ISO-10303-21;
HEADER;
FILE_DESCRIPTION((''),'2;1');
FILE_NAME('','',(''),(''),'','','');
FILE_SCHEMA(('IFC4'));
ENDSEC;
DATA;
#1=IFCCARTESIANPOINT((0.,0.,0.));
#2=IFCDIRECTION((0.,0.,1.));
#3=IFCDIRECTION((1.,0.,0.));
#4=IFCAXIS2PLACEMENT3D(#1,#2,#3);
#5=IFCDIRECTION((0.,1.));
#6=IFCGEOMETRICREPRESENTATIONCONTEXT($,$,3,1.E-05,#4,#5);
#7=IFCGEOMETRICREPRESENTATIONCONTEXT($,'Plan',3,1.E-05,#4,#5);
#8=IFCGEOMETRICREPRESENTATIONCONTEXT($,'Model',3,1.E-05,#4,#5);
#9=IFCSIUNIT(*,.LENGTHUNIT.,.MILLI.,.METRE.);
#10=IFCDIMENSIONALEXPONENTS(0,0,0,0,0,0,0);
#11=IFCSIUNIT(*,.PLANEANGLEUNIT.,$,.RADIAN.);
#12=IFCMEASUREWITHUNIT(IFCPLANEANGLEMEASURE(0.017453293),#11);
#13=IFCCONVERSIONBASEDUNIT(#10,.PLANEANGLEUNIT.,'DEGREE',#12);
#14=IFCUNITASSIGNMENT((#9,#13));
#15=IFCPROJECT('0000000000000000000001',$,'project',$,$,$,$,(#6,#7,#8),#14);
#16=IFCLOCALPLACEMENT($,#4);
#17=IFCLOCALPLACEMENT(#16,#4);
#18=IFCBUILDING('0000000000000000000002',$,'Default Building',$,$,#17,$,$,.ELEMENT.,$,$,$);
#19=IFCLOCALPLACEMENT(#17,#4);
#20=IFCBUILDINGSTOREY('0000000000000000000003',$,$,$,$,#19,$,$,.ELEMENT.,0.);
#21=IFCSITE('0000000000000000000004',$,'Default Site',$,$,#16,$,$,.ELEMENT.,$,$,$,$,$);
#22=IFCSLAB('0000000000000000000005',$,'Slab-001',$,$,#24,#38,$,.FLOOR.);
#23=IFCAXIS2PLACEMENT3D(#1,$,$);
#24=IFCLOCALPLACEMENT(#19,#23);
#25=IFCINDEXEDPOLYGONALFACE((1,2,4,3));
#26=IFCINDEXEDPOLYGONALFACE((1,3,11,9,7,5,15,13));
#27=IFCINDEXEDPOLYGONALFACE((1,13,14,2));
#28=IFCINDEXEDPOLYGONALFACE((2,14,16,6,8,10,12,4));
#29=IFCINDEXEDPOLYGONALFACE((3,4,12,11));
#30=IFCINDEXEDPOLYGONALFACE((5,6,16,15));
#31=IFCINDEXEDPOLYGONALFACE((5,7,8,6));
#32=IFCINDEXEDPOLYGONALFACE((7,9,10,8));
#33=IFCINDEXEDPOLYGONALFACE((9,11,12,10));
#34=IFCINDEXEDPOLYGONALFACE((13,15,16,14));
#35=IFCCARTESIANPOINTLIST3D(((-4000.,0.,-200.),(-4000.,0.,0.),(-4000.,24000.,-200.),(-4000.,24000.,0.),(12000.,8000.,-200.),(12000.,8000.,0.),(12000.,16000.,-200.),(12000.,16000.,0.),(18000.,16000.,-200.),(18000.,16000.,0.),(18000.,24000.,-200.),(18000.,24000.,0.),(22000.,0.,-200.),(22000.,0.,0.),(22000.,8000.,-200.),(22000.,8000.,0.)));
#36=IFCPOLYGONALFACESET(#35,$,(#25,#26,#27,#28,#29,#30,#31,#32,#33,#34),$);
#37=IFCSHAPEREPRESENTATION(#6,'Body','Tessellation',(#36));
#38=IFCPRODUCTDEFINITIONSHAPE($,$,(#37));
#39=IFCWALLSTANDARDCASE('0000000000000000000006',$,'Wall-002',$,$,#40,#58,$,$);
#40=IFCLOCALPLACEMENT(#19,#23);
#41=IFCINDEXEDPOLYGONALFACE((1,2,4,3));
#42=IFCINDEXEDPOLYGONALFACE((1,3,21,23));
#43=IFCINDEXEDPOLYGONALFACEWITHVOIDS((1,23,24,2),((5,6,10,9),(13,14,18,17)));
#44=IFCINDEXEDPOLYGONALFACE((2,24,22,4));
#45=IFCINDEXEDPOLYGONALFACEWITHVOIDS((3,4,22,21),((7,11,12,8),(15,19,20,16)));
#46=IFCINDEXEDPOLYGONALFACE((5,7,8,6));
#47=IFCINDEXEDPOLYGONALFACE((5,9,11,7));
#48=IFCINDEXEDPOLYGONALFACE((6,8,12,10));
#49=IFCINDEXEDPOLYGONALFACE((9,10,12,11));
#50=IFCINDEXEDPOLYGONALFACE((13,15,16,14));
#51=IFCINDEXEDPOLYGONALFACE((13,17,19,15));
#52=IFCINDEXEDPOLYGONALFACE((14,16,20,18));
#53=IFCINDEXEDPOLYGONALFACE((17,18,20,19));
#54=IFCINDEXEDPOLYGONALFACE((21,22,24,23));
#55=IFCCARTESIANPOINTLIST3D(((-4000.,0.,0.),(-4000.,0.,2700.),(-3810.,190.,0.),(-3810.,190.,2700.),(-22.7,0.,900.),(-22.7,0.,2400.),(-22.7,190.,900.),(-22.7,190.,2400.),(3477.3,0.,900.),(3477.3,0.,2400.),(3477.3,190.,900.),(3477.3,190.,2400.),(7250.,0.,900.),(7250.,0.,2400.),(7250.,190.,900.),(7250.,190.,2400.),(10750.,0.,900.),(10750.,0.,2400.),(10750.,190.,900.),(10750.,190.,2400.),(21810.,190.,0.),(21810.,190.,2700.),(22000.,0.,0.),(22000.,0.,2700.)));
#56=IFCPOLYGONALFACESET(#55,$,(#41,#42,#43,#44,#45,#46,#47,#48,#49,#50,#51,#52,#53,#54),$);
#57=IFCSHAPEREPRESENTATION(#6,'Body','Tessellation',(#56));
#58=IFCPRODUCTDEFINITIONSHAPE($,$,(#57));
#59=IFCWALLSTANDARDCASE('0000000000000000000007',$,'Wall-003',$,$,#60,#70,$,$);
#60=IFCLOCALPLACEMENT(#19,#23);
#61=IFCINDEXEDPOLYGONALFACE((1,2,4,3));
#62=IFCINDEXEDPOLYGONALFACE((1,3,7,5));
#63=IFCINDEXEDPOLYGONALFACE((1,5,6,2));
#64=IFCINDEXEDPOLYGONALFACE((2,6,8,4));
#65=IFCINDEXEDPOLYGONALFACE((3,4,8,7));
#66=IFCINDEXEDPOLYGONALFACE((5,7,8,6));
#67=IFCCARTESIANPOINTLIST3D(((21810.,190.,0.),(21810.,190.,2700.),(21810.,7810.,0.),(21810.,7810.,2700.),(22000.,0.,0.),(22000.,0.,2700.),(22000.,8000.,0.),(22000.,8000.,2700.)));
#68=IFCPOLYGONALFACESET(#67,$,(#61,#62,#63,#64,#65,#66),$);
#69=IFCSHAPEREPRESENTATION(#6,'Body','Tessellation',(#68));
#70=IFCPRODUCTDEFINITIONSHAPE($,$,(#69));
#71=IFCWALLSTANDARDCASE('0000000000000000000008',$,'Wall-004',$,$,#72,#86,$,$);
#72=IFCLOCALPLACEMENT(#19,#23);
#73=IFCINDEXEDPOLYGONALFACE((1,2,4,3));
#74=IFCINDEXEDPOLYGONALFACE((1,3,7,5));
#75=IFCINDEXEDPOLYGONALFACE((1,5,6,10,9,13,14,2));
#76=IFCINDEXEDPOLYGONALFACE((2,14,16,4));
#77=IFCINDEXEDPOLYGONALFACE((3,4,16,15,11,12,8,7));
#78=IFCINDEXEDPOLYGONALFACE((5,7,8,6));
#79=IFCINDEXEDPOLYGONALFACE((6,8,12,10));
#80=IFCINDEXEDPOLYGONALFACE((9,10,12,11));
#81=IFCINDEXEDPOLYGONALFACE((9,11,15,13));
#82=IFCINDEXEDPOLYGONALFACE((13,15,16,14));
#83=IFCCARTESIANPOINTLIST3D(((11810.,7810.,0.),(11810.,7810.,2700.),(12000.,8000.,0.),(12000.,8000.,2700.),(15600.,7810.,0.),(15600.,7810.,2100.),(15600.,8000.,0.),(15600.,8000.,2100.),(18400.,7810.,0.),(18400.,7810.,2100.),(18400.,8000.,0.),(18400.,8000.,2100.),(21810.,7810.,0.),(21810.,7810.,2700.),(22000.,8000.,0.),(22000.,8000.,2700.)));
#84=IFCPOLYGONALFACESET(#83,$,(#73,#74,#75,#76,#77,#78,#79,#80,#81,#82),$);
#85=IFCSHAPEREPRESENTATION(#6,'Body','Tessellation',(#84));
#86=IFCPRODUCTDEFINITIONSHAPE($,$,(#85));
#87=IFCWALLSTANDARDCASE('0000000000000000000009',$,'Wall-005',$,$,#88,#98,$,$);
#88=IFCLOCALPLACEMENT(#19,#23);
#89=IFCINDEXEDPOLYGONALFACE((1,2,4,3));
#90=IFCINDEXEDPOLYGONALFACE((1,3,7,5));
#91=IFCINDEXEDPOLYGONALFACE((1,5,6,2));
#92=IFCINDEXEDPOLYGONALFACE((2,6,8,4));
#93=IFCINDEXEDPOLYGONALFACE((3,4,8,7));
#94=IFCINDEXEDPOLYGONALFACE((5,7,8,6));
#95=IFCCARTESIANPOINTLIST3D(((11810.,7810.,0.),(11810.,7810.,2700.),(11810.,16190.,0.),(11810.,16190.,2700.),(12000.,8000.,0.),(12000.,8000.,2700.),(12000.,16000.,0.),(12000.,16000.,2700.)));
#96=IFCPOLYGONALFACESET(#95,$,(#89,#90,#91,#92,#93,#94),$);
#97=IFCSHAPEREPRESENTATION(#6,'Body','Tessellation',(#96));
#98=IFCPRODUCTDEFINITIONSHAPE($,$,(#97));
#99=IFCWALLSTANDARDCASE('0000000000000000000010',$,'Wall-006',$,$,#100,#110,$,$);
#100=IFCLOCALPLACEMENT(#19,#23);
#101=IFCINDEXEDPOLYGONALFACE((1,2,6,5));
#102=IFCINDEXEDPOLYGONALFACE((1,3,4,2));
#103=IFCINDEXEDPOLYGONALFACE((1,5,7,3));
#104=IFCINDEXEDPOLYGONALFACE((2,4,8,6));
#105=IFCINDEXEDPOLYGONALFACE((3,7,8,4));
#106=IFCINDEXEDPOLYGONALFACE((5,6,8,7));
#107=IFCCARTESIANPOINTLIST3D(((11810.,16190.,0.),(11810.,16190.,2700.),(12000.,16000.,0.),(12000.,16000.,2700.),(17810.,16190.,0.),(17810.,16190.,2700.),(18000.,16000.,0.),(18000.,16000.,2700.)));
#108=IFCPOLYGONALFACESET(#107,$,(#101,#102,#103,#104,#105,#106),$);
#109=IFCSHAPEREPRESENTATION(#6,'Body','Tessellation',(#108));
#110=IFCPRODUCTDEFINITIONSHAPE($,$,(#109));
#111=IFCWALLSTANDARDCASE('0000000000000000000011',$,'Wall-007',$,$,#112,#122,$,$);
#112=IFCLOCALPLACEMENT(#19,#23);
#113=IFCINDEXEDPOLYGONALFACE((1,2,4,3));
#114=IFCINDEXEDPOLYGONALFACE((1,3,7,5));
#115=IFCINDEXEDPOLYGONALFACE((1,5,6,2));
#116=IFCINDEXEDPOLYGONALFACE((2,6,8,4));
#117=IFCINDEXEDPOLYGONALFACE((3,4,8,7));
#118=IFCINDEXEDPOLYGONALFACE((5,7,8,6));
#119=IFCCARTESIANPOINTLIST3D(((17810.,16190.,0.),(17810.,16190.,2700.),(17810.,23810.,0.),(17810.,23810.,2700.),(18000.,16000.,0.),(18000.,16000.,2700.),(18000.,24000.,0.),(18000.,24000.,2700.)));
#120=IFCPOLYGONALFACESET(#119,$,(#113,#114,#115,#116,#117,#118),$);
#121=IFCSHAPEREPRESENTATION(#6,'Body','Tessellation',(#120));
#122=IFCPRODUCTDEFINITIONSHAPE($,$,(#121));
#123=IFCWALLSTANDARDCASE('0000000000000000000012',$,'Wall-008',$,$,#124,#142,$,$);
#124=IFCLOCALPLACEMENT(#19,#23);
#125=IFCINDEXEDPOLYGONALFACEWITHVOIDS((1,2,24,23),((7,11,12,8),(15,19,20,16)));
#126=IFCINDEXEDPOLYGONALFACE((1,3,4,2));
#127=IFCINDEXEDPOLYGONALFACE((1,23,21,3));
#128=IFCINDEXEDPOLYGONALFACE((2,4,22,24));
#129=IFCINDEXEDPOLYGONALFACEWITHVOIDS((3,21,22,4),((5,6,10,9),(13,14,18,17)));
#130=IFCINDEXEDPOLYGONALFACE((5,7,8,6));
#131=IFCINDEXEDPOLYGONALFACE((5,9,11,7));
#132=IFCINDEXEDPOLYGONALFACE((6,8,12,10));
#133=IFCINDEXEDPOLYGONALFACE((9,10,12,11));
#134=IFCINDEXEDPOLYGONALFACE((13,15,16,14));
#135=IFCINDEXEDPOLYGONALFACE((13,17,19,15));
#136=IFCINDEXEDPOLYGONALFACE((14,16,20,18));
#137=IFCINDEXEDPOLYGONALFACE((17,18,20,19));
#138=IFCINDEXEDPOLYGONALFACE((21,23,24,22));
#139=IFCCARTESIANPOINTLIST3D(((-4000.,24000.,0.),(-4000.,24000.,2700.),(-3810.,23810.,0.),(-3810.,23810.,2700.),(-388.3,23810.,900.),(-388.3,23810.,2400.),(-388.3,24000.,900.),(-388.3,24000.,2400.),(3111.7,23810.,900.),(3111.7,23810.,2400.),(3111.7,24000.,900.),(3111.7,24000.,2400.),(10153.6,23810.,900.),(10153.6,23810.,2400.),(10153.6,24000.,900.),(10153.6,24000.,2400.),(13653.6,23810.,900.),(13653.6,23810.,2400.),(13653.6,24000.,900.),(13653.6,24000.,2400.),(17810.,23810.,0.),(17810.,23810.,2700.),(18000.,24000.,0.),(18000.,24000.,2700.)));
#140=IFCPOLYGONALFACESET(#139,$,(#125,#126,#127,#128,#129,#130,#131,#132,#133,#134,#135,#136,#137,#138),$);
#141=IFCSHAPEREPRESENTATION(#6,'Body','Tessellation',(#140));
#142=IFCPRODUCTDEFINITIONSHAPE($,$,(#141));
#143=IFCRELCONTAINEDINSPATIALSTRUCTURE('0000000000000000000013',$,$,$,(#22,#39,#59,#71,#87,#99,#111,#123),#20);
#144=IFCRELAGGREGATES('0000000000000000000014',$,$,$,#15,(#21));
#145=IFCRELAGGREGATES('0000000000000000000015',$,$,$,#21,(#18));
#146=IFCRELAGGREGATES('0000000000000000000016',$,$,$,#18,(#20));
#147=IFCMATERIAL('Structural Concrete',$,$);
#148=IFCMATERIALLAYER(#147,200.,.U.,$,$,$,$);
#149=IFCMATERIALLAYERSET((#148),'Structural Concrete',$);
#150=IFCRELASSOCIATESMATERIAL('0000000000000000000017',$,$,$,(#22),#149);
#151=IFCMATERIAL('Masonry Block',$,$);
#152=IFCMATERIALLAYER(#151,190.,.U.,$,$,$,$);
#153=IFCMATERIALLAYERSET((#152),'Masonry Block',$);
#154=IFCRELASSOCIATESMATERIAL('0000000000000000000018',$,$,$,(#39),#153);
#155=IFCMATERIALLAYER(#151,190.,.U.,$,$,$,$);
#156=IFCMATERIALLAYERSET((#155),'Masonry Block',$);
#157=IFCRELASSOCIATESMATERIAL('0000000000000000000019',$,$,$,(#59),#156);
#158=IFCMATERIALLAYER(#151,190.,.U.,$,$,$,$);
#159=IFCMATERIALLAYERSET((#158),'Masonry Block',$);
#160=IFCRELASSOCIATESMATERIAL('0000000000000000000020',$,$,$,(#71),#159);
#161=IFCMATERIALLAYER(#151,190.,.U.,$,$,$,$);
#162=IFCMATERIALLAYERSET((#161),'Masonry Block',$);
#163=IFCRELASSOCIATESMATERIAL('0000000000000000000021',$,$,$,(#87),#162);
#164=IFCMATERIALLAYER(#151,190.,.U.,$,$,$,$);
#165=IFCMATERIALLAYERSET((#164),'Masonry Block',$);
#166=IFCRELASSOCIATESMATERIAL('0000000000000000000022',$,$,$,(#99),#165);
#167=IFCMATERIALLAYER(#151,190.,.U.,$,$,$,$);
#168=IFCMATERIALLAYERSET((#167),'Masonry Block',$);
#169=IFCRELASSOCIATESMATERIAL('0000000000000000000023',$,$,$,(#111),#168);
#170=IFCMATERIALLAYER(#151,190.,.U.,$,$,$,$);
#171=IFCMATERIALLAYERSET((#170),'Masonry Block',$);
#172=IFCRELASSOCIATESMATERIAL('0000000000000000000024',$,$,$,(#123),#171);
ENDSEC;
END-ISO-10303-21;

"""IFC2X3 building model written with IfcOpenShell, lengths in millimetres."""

from ifc_helpers import new_model, entity, si_unit, converted_unit, direction, frame, origin_with_axes, place, context, project, spatial, polyline, outline, extrude, material, layer, layer_set, layer_usage, element, save


model = new_model("IFC2X3")

# Units and contexts
context_of_model = context(None, 3, precision=1e-05, world=origin_with_axes(), true_north=direction((0.0, 1.0)))
plan_context = context("Plan", 3, precision=1e-05, world=origin_with_axes(), true_north=direction((0.0, 1.0)))
model_context = context("Model", 3, precision=1e-05, world=origin_with_axes(), true_north=direction((0.0, 1.0)))
ifc_project = project(units=[si_unit("LENGTHUNIT", "METRE", prefix="MILLI"), converted_unit("PLANEANGLEUNIT", "DEGREE", entity("IfcPlaneAngleMeasure", 0.017453293), si_unit("PLANEANGLEUNIT", "RADIAN"), dimensions=[0, 0, 0, 0, 0, 0, 0])], contexts=[context_of_model, plan_context, model_context])

# Site, building, storey
site_placement = place(None, origin_with_axes())
site = spatial("IfcSite", under=ifc_project, at=site_placement, Name="Default Site", CompositionType="ELEMENT")
building_placement = place(site_placement, origin_with_axes())
building = spatial("IfcBuilding", under=site, at=building_placement, Name="Default Building", CompositionType="ELEMENT")
storey_placement = place(building_placement, origin_with_axes())
storey = spatial("IfcBuildingStorey", under=building, at=storey_placement, CompositionType="ELEMENT", Elevation=0.0)

# Slab
ifc_material_1 = material(Name="Structural Concrete")
ifc_layer_1 = layer(ifc_material_1, 200.0, ventilated="UNKNOWN")
ifc_layer_set_1 = layer_set([ifc_layer_1], Name="Structural Concrete")
ifc_layer_usage_1 = layer_usage(ifc_layer_set_1, "AXIS3", "NEGATIVE", 200.0)
slab_placement = place(storey_placement, frame((-4000.0, 0.0, -200.0), z_axis=(0.0, 0.0, 1.0), x_axis=(0.0, 1.0, 0.0)))
element("IfcSlab", 1, at=slab_placement, inside=storey, material=ifc_layer_usage_1, Name="Slab-001", PredefinedType="FLOOR", context=context_of_model, shape_type="SweptSolid", body=[
    extrude(outline(polyline([(0.0, 0.0), (24000.0, 0.0), (24000.0, -22000.0), (16000.0, -22000.0), (16000.0, -16000.0), (8000.0, -16000.0), (8000.0, -26000.0), (0.0, -26000.0), (0.0, 0.0)])), origin_with_axes(), (0.0, 0.0, 1.0), 200.0),
])

# Wall, openings
ifc_material_2 = material(Name="Masonry Block")
ifc_layer_2 = layer(ifc_material_2, 190.0, ventilated="UNKNOWN")
ifc_layer_set_2 = layer_set([ifc_layer_2], Name="Masonry Block")
ifc_layer_usage_2 = layer_usage(ifc_layer_set_2, "AXIS2", "POSITIVE", 0.0)
wall_1_placement = place(storey_placement, frame((-4000.0, 0.0, 0.0), z_axis=(0.0, 0.0, 1.0), x_axis=(1.0, 0.0, 0.0)))
wall_1 = element("IfcWallStandardCase", 2, at=wall_1_placement, inside=storey, material=ifc_layer_usage_2, Name="Wall-002", context=context_of_model, shape_type="SweptSolid", body=[
    extrude(outline(polyline([(0.0, 0.0), (26000.0, 0.0), (25810.0, 190.0), (190.0, 190.0), (0.0, 0.0)])), origin_with_axes(), (0.0, 0.0, 1.0), 2700.0),
])
opening_1_placement = place(wall_1_placement, frame((13000.0, 0.0, 900.0), z_axis=(0.0, 0.0, 1.0), x_axis=(1.0, 0.0, 0.0)))
element("IfcOpeningElement", 3, at=opening_1_placement, cuts=wall_1, ObjectType="Opening", context=model_context, shape_type="SweptSolid", body=[
    extrude(outline(polyline([(-1750.0, 1500.0), (-1750.0, 0.0), (1750.0, 0.0), (1750.0, 1500.0), (-1750.0, 1500.0)])), frame((0.0, 0.0, 0.0), z_axis=(0.0, 1.0, 0.0), x_axis=(-1.0, 0.0, 0.0)), (0.0, 0.0, 1.0), 190.0),
])
opening_2_placement = place(wall_1_placement, frame((5727.3, 0.0, 900.0), z_axis=(0.0, 0.0, 1.0), x_axis=(1.0, 0.0, 0.0)))
element("IfcOpeningElement", 4, at=opening_2_placement, cuts=wall_1, ObjectType="Opening", context=model_context, shape_type="SweptSolid", body=[
    extrude(outline(polyline([(1750.0, 1500.0), (-1750.0, 1500.0), (-1750.0, 0.0), (1750.0, 0.0), (1750.0, 1500.0)])), frame((0.0, 0.0, 0.0), z_axis=(0.0, 1.0, 0.0), x_axis=(-1.0, 0.0, 0.0)), (0.0, 0.0, 1.0), 190.0),
])

# Wall
ifc_layer_3 = layer(ifc_material_2, 190.0, ventilated="UNKNOWN")
ifc_layer_set_3 = layer_set([ifc_layer_3], Name="Masonry Block")
ifc_layer_usage_3 = layer_usage(ifc_layer_set_3, "AXIS2", "POSITIVE", 0.0)
wall_2_placement = place(storey_placement, frame((22000.0, 0.0, 0.0), z_axis=(0.0, 0.0, 1.0), x_axis=(0.0, 1.0, 0.0)))
element("IfcWallStandardCase", 5, at=wall_2_placement, inside=storey, material=ifc_layer_usage_3, Name="Wall-003", context=context_of_model, shape_type="SweptSolid", body=[
    extrude(outline(polyline([(0.0, 0.0), (8000.0, 0.0), (7810.0, 190.0), (190.0, 190.0), (0.0, 0.0)])), origin_with_axes(), (0.0, 0.0, 1.0), 2700.0),
])

# Wall, opening
ifc_layer_4 = layer(ifc_material_2, 190.0, ventilated="UNKNOWN")
ifc_layer_set_4 = layer_set([ifc_layer_4], Name="Masonry Block")
ifc_layer_usage_4 = layer_usage(ifc_layer_set_4, "AXIS2", "POSITIVE", 0.0)
wall_3_placement = place(storey_placement, frame((22000.0, 8000.0, 0.0), z_axis=(0.0, 0.0, 1.0), x_axis=(-1.0, 0.0, 0.0)))
wall_3 = element("IfcWallStandardCase", 6, at=wall_3_placement, inside=storey, material=ifc_layer_usage_4, Name="Wall-004", context=context_of_model, shape_type="SweptSolid", body=[
    extrude(outline(polyline([(0.0, 0.0), (10000.0, 0.0), (10190.0, 190.0), (190.0, 190.0), (0.0, 0.0)])), origin_with_axes(), (0.0, 0.0, 1.0), 2700.0),
])
opening_3_placement = place(wall_3_placement, frame((5000.0, 0.0, 0.0), z_axis=(0.0, 0.0, 1.0), x_axis=(1.0, 0.0, 0.0)))
element("IfcOpeningElement", 7, at=opening_3_placement, cuts=wall_3, ObjectType="Opening", context=model_context, shape_type="SweptSolid", body=[
    extrude(outline(polyline([(1400.0, 2100.0), (-1400.0, 2100.0), (-1400.0, 0.0), (1400.0, 0.0), (1400.0, 2100.0)])), frame((0.0, 0.0, 0.0), z_axis=(0.0, 1.0, 0.0), x_axis=(-1.0, 0.0, 0.0)), (0.0, 0.0, 1.0), 190.0),
])

# Walls
ifc_layer_5 = layer(ifc_material_2, 190.0, ventilated="UNKNOWN")
ifc_layer_set_5 = layer_set([ifc_layer_5], Name="Masonry Block")
ifc_layer_usage_5 = layer_usage(ifc_layer_set_5, "AXIS2", "POSITIVE", 0.0)
wall_4_placement = place(storey_placement, frame((12000.0, 8000.0, 0.0), z_axis=(0.0, 0.0, 1.0), x_axis=(0.0, 1.0, 0.0)))
element("IfcWallStandardCase", 8, at=wall_4_placement, inside=storey, material=ifc_layer_usage_5, Name="Wall-005", context=context_of_model, shape_type="SweptSolid", body=[
    extrude(outline(polyline([(0.0, 0.0), (8000.0, 0.0), (8190.0, 190.0), (-190.0, 190.0), (0.0, 0.0)])), origin_with_axes(), (0.0, 0.0, 1.0), 2700.0),
])
ifc_layer_6 = layer(ifc_material_2, 190.0, ventilated="UNKNOWN")
ifc_layer_set_6 = layer_set([ifc_layer_6], Name="Masonry Block")
ifc_layer_usage_6 = layer_usage(ifc_layer_set_6, "AXIS2", "POSITIVE", 0.0)
wall_5_placement = place(storey_placement, frame((12000.0, 16000.0, 0.0), z_axis=(0.0, 0.0, 1.0), x_axis=(1.0, 0.0, 0.0)))
element("IfcWallStandardCase", 9, at=wall_5_placement, inside=storey, material=ifc_layer_usage_6, Name="Wall-006", context=context_of_model, shape_type="SweptSolid", body=[
    extrude(outline(polyline([(0.0, 0.0), (6000.0, 0.0), (5810.0, 190.0), (-190.0, 190.0), (0.0, 0.0)])), origin_with_axes(), (0.0, 0.0, 1.0), 2700.0),
])
ifc_layer_7 = layer(ifc_material_2, 190.0, ventilated="UNKNOWN")
ifc_layer_set_7 = layer_set([ifc_layer_7], Name="Masonry Block")
ifc_layer_usage_7 = layer_usage(ifc_layer_set_7, "AXIS2", "POSITIVE", 0.0)
wall_6_placement = place(storey_placement, frame((18000.0, 16000.0, 0.0), z_axis=(0.0, 0.0, 1.0), x_axis=(0.0, 1.0, 0.0)))
element("IfcWallStandardCase", 10, at=wall_6_placement, inside=storey, material=ifc_layer_usage_7, Name="Wall-007", context=context_of_model, shape_type="SweptSolid", body=[
    extrude(outline(polyline([(0.0, 0.0), (8000.0, 0.0), (7810.0, 190.0), (190.0, 190.0), (0.0, 0.0)])), origin_with_axes(), (0.0, 0.0, 1.0), 2700.0),
])

# Wall, openings
ifc_layer_8 = layer(ifc_material_2, 190.0, ventilated="UNKNOWN")
ifc_layer_set_8 = layer_set([ifc_layer_8], Name="Masonry Block")
ifc_layer_usage_8 = layer_usage(ifc_layer_set_8, "AXIS2", "POSITIVE", 0.0)
wall_7_placement = place(storey_placement, frame((18000.0, 24000.0, 0.0), z_axis=(0.0, 0.0, 1.0), x_axis=(-1.0, 0.0, 0.0)))
wall_7 = element("IfcWallStandardCase", 11, at=wall_7_placement, inside=storey, material=ifc_layer_usage_8, Name="Wall-008", context=context_of_model, shape_type="SweptSolid", body=[
    extrude(outline(polyline([(0.0, 0.0), (22000.0, 0.0), (21810.0, 190.0), (190.0, 190.0), (0.0, 0.0)])), origin_with_axes(), (0.0, 0.0, 1.0), 2700.0),
])
opening_4_placement = place(wall_7_placement, frame((16638.3, 0.0, 900.0), z_axis=(0.0, 0.0, 1.0), x_axis=(1.0, 0.0, 0.0)))
element("IfcOpeningElement", 12, at=opening_4_placement, cuts=wall_7, ObjectType="Opening", context=model_context, shape_type="SweptSolid", body=[
    extrude(outline(polyline([(-1750.0, 1500.0), (-1750.0, 0.0), (1750.0, 0.0), (1750.0, 1500.0), (-1750.0, 1500.0)])), frame((0.0, 0.0, 0.0), z_axis=(0.0, 1.0, 0.0), x_axis=(-1.0, 0.0, 0.0)), (0.0, 0.0, 1.0), 190.0),
])
opening_5_placement = place(wall_7_placement, frame((6096.4, 0.0, 900.0), z_axis=(0.0, 0.0, 1.0), x_axis=(1.0, 0.0, 0.0)))
element("IfcOpeningElement", 13, at=opening_5_placement, cuts=wall_7, ObjectType="Opening", context=model_context, shape_type="SweptSolid", body=[
    extrude(outline(polyline([(1750.0, 1500.0), (-1750.0, 1500.0), (-1750.0, 0.0), (1750.0, 0.0), (1750.0, 1500.0)])), frame((0.0, 0.0, 0.0), z_axis=(0.0, 1.0, 0.0), x_axis=(-1.0, 0.0, 0.0)), (0.0, 0.0, 1.0), 190.0),
])

save(model, "model.ifc")
